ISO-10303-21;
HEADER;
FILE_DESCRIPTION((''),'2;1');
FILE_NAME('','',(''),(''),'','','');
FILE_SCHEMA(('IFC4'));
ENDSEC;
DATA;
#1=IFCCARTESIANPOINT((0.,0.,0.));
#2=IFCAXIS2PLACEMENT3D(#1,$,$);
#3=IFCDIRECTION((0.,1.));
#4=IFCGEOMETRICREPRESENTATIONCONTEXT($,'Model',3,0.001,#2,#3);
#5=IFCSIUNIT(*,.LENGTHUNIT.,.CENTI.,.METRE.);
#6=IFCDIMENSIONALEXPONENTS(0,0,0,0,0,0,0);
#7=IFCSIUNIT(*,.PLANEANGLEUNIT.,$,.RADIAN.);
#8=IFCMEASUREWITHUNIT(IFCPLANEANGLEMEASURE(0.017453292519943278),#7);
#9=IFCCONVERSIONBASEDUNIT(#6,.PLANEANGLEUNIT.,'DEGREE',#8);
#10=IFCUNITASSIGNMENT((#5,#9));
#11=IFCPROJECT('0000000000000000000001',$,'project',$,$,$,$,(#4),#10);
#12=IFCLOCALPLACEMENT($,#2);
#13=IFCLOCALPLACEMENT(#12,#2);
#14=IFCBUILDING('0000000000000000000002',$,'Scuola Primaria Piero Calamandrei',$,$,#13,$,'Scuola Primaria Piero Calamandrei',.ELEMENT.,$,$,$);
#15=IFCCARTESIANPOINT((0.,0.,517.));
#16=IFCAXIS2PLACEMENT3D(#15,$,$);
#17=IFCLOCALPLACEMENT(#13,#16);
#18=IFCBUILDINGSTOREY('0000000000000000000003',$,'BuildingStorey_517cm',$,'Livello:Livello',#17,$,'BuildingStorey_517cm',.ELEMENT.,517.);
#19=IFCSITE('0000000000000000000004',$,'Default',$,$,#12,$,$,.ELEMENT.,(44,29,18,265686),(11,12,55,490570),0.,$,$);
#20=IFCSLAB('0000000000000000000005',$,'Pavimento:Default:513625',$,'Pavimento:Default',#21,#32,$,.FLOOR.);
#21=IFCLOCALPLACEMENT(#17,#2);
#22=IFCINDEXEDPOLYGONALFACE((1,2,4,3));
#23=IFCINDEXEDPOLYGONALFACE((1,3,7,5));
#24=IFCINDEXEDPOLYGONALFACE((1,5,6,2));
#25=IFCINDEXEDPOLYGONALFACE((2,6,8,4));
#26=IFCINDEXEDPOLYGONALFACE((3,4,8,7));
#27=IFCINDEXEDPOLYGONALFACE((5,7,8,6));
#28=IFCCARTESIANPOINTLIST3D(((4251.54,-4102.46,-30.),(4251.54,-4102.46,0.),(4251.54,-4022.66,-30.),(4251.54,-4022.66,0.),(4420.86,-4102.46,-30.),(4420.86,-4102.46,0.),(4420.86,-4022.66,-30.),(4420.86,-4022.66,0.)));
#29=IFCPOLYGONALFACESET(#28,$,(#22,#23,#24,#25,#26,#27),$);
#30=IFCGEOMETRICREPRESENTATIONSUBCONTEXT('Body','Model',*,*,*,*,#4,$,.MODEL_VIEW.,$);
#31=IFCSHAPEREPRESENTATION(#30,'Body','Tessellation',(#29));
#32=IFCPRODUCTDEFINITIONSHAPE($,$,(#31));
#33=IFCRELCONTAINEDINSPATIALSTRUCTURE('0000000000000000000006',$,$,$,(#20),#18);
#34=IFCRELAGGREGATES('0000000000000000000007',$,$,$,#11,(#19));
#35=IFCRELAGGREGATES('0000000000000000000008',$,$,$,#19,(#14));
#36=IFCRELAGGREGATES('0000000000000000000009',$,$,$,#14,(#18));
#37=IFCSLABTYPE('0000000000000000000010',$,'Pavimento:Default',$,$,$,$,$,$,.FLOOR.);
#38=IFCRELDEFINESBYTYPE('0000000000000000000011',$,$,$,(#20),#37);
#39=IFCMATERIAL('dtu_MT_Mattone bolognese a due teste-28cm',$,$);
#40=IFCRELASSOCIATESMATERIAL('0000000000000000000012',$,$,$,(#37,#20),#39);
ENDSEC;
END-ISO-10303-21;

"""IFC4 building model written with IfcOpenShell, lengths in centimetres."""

from ifc_helpers import new_model, entity, si_unit, converted_unit, direction, frame, origin, place, context, subcontext, project, spatial, indexed_curve, outline, extrude, material, type_object, element, save


model = new_model("IFC4")

# Units and contexts
model_context = context("Model", 3, precision=0.001, world=origin(), true_north=direction((0.0, 1.0)))
body_context = subcontext(model_context, "Body", "Model", "MODEL_VIEW")
ifc_project = project(units=[si_unit("LENGTHUNIT", "METRE", prefix="CENTI"), converted_unit("PLANEANGLEUNIT", "DEGREE", entity("IfcPlaneAngleMeasure", 0.017453292519943278), si_unit("PLANEANGLEUNIT", "RADIAN"), dimensions=[0, 0, 0, 0, 0, 0, 0])], contexts=[model_context])

# Site, building, storey
site_placement = place(None, origin())
site = spatial("IfcSite", under=ifc_project, at=site_placement, Name="Default", CompositionType="ELEMENT", RefLatitude=(44, 29, 18, 265686), RefLongitude=(11, 12, 55, 490570), RefElevation=0.0)
building_placement = place(site_placement, origin())
building = spatial("IfcBuilding", under=site, at=building_placement, Name="Scuola Primaria Piero Calamandrei", LongName="Scuola Primaria Piero Calamandrei", CompositionType="ELEMENT")
storey_placement = place(building_placement, frame((0.0, 0.0, 517.0)))
storey = spatial("IfcBuildingStorey", under=building, at=storey_placement, Name="BuildingStorey_517cm", ObjectType="Livello:Livello", LongName="BuildingStorey_517cm", CompositionType="ELEMENT", Elevation=517.0)

# Slab
ifc_material_1 = material(Name="dtu_MT_Mattone bolognese a due teste-28cm")
slab_type_1 = type_object("IfcSlabType", Name="Pavimento:Default", PredefinedType="FLOOR", material=ifc_material_1)
slab_1_placement = place(storey_placement, origin())
element("IfcSlab", 1, at=slab_1_placement, inside=storey, type_object=slab_type_1, material=ifc_material_1, Name="Pavimento:Default:513625", ObjectType="Pavimento:Default", PredefinedType="FLOOR", context=body_context, shape_type="SweptSolid", body=[
    extrude(outline(indexed_curve([(-39.9, -84.66), (39.9, -84.66), (39.9, 84.66), (-39.9, 84.66), (-39.9, -84.66)], self_intersect=False)), frame((4336.2, -4062.56, 0.0), z_axis=(0.0, 0.0, -1.0), x_axis=(0.0, 1.0, 0.0)), (0.0, 0.0, 1.0), 30.0),
])

save(model, "model.ifc")
